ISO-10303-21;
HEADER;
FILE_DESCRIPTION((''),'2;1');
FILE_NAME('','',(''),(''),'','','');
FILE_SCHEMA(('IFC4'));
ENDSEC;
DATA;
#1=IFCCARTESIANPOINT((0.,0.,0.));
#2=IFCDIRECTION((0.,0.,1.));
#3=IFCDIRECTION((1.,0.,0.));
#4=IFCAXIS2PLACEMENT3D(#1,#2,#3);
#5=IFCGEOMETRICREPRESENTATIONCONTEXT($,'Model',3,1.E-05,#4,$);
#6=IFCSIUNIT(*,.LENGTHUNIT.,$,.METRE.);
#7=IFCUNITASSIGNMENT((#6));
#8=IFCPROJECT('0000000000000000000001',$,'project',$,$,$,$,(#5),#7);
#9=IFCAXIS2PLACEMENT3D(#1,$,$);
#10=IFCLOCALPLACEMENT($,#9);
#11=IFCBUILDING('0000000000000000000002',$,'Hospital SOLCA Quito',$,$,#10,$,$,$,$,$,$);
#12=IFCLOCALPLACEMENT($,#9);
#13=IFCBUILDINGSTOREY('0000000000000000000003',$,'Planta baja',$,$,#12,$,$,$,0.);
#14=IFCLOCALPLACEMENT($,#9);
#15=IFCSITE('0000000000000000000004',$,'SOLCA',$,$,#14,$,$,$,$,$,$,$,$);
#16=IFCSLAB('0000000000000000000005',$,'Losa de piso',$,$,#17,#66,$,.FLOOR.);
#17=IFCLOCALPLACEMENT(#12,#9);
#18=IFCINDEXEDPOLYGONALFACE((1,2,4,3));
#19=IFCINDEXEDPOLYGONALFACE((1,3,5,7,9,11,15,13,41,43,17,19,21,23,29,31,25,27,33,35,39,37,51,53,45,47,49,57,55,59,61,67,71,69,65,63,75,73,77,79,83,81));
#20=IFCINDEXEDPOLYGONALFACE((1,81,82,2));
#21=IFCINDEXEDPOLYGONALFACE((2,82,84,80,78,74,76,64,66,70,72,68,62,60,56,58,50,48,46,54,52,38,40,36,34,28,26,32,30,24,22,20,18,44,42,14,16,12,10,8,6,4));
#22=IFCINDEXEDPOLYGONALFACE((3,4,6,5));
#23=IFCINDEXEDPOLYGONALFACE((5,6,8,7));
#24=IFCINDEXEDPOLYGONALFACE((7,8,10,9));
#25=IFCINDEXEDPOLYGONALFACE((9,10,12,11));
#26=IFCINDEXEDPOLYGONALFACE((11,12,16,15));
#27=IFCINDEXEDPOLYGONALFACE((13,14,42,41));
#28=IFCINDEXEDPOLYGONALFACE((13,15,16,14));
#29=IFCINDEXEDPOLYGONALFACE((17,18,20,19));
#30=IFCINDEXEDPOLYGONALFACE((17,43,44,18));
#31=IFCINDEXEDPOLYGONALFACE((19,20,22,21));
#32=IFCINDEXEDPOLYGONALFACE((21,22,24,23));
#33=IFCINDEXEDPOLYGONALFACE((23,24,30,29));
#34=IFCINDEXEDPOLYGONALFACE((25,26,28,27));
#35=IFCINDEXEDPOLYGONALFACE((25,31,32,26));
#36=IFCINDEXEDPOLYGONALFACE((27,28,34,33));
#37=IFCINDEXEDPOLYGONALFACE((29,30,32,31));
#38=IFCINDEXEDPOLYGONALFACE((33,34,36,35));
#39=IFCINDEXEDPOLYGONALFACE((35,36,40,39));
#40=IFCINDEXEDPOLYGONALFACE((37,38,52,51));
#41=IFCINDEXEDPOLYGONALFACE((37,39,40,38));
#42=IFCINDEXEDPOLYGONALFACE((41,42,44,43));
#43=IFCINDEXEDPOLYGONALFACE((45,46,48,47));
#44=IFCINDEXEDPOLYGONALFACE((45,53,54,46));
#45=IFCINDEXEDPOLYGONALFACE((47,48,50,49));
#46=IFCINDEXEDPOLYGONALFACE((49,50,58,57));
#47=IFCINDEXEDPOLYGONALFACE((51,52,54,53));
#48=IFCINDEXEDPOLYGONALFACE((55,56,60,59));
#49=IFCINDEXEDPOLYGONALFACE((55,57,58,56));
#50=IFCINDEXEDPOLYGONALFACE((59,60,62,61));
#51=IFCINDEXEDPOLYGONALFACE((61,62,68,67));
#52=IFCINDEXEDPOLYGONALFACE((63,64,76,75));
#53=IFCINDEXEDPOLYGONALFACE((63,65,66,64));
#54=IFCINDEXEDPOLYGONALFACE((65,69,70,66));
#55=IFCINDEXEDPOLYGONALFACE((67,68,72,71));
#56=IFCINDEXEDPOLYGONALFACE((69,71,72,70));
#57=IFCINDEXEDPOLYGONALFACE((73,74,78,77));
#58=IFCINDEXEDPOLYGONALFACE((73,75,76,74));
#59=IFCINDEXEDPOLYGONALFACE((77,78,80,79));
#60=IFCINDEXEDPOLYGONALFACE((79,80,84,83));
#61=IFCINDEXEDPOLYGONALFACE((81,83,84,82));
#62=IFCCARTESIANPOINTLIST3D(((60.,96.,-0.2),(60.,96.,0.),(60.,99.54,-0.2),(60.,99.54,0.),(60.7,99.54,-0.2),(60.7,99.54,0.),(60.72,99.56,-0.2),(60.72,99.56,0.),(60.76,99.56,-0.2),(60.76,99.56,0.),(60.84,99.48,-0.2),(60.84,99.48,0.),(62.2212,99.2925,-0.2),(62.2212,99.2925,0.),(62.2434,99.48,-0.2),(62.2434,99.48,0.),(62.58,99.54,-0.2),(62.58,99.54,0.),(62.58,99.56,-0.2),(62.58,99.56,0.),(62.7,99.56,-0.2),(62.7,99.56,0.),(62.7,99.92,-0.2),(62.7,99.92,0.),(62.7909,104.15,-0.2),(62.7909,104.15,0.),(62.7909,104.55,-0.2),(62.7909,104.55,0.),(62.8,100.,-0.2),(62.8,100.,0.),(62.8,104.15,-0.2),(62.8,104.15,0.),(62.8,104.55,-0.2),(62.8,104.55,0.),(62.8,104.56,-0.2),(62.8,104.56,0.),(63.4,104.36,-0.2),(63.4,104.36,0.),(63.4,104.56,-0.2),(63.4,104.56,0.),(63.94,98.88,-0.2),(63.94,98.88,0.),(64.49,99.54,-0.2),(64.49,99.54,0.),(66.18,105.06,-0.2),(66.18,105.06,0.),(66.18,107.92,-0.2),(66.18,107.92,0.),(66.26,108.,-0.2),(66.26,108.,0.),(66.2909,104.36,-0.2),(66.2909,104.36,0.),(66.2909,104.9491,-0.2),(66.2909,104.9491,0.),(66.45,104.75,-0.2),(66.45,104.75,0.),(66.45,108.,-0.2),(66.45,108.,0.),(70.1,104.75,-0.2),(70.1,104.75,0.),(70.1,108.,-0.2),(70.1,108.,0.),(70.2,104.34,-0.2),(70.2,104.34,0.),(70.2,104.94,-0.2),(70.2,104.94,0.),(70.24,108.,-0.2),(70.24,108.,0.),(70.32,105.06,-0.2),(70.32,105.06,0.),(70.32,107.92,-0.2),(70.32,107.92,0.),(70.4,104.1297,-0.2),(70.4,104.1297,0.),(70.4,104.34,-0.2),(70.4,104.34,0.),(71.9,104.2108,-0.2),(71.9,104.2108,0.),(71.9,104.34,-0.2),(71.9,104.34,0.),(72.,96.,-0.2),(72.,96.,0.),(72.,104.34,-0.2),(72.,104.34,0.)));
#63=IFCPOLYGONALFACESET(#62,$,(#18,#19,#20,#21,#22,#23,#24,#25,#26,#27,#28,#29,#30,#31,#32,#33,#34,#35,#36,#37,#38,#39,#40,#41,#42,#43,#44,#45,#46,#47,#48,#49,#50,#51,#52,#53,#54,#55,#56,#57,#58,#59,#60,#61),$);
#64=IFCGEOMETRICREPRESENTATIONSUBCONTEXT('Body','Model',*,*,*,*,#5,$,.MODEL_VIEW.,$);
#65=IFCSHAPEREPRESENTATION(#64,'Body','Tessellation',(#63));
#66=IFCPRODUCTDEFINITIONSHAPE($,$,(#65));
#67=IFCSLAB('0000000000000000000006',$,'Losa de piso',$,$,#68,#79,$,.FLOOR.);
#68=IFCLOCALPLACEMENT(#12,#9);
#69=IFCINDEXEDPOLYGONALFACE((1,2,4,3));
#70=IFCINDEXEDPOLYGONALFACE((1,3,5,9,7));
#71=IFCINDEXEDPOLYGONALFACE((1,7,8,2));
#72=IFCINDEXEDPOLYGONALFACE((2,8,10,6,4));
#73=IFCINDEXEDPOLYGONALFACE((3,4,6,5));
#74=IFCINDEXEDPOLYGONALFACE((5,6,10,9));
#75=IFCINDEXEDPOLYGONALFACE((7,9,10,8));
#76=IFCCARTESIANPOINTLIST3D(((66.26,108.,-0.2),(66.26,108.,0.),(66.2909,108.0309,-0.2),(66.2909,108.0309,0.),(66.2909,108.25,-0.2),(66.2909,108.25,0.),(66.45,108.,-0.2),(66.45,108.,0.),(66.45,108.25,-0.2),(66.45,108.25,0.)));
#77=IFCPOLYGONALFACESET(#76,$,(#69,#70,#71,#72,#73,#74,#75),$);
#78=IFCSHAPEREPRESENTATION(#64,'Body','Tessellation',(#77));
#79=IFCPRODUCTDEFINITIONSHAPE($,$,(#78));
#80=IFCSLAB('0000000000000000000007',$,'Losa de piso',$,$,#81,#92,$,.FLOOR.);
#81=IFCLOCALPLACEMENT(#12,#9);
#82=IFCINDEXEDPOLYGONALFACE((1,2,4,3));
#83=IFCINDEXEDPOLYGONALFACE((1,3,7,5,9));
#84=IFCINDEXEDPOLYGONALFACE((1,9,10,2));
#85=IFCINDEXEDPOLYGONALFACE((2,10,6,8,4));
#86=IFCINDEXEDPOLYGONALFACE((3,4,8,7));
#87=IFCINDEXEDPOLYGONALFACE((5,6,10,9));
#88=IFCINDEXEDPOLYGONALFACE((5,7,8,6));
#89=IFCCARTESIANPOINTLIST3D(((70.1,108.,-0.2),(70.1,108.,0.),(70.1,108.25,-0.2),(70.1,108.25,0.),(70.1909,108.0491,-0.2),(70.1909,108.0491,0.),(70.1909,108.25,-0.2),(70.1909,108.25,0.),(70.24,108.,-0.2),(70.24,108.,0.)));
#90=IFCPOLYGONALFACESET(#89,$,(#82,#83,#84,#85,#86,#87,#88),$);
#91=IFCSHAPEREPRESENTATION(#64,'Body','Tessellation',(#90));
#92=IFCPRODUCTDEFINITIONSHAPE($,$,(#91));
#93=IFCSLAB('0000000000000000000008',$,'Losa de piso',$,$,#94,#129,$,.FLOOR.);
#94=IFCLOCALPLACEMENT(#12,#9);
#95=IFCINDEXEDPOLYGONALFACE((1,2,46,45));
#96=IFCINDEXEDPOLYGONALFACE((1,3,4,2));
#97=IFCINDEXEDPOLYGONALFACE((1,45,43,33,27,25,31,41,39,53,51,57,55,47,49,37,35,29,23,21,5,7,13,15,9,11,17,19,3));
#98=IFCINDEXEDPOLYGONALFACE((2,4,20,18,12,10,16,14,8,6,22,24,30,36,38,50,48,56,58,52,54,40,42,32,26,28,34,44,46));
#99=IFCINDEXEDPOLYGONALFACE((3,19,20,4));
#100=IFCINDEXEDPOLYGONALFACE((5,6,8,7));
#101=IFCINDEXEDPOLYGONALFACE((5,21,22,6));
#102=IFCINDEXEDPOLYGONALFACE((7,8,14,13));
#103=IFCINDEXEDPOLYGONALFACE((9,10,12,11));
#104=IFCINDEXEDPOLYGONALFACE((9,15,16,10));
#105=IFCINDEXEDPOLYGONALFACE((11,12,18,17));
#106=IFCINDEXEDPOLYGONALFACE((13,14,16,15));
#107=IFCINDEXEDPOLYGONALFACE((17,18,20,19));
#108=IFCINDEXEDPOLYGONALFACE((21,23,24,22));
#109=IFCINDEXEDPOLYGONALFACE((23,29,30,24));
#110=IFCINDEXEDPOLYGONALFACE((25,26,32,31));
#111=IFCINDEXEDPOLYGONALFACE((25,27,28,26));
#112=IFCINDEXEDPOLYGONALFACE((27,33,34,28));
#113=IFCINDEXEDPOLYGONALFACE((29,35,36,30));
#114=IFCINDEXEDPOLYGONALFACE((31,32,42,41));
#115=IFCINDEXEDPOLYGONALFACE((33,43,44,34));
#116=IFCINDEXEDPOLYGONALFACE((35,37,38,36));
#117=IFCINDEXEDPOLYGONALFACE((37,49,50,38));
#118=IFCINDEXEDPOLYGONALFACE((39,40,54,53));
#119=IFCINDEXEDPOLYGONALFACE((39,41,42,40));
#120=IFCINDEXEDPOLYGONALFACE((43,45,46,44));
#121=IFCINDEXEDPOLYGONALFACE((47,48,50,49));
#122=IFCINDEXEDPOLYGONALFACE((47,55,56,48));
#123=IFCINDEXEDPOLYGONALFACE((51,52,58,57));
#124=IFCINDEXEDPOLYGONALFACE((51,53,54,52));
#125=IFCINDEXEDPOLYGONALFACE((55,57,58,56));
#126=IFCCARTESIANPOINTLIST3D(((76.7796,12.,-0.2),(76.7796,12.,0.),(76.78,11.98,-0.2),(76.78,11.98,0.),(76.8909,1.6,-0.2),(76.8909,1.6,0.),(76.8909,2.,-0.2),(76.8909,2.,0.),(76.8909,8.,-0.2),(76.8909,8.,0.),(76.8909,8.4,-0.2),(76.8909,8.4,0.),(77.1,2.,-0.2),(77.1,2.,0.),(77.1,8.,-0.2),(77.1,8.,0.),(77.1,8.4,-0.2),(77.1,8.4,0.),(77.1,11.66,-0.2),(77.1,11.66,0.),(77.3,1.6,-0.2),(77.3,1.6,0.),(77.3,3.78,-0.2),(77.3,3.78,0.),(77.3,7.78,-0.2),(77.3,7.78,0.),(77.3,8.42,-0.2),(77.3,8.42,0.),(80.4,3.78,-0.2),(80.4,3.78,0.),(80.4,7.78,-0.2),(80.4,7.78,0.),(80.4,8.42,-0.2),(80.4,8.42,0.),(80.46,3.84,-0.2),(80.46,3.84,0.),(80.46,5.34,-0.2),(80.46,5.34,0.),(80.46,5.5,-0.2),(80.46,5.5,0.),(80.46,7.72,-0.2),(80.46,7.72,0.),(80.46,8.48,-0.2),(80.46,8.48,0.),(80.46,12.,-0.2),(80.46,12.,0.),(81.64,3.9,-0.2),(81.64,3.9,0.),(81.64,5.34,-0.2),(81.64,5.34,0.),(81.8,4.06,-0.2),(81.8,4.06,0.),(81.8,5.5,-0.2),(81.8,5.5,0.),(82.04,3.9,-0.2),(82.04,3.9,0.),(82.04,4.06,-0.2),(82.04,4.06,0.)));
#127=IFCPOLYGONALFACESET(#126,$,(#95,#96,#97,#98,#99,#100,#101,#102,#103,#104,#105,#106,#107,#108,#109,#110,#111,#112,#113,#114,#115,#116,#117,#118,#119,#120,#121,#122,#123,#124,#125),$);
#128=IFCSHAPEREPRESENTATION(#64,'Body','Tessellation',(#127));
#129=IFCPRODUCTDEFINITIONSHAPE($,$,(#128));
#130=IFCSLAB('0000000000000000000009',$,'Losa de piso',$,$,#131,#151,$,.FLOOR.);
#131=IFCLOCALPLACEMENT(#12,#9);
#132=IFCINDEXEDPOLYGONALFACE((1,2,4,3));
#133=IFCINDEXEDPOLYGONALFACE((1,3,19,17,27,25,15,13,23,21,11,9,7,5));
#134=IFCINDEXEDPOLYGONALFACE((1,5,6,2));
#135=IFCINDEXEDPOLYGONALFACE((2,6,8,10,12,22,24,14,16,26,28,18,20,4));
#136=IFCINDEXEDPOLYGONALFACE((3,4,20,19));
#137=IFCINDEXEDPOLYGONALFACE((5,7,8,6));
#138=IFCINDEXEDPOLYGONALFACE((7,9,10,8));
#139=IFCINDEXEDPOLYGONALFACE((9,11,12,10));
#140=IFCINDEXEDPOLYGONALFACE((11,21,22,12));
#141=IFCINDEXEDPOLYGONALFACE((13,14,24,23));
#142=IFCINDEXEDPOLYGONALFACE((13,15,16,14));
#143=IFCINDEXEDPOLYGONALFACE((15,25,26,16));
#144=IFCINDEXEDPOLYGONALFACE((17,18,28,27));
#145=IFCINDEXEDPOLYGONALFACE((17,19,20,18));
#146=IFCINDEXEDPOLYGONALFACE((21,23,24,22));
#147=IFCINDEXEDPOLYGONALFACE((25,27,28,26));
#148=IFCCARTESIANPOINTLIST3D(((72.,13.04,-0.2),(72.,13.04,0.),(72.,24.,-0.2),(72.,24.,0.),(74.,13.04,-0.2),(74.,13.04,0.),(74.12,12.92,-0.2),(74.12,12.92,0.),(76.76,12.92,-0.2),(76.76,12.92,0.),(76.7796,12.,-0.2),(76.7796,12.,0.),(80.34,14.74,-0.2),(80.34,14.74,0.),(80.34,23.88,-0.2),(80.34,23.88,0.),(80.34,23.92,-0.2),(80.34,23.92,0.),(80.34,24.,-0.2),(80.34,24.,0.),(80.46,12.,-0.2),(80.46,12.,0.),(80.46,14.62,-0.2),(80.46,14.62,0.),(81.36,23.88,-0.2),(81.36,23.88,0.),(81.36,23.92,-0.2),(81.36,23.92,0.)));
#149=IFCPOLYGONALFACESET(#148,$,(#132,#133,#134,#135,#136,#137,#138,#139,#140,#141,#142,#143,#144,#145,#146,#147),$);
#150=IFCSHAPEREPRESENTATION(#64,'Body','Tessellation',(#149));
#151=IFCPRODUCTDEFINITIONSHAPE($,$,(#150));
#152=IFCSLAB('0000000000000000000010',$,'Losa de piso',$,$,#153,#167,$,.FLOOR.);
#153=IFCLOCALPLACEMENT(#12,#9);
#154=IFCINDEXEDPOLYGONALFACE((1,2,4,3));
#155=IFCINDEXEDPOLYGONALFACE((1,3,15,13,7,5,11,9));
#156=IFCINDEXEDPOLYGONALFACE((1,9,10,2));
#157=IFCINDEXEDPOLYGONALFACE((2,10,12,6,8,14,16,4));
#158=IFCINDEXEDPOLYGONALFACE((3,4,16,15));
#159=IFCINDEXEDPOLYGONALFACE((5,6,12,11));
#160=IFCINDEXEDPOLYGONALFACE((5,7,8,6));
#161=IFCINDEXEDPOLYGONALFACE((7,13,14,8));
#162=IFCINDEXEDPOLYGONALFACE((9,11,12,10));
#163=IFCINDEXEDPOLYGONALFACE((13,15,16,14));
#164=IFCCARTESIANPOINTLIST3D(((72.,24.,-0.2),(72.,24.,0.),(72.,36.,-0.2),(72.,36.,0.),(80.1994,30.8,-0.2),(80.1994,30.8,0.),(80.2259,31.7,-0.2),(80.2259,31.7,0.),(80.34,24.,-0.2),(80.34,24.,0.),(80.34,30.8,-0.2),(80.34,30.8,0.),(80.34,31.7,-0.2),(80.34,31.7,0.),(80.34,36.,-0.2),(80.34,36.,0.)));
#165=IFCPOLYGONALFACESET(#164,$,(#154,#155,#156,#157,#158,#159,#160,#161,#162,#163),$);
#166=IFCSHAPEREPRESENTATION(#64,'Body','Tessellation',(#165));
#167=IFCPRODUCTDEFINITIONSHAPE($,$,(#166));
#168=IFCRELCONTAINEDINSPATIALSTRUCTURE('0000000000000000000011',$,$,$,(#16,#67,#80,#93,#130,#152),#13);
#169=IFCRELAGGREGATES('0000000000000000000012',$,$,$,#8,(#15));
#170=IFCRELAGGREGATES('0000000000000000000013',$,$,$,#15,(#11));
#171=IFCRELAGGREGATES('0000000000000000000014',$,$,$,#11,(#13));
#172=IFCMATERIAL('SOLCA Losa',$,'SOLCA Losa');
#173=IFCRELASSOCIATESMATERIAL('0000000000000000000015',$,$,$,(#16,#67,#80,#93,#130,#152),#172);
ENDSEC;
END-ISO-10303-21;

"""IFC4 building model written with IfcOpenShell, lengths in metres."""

from ifc_helpers import new_model, si_unit, frame, origin, origin_with_axes, place, context, subcontext, project, spatial, polyline, outline, extrude, material, element, save


model = new_model("IFC4")

# Units and contexts
model_context = context("Model", 3, precision=1e-05, world=origin_with_axes())
body_context = subcontext(model_context, "Body", "Model", "MODEL_VIEW")
ifc_project = project(units=[si_unit("LENGTHUNIT", "METRE")], contexts=[model_context])

# Site, building, storey
site_placement = place(None, origin())
site = spatial("IfcSite", under=ifc_project, at=site_placement, Name="SOLCA")
building_placement = place(None, origin())
building = spatial("IfcBuilding", under=site, at=building_placement, Name="Hospital SOLCA Quito")
storey_placement = place(None, origin())
storey = spatial("IfcBuildingStorey", under=building, at=storey_placement, Name="Planta baja", Elevation=0.0)

# Slabs
ifc_material_1 = material(Name="SOLCA Losa", Category="SOLCA Losa")
slab_1_placement = place(storey_placement, origin_with_axes())
element("IfcSlab", 1, at=slab_1_placement, inside=storey, material=ifc_material_1, Name="Losa de piso", PredefinedType="FLOOR", context=body_context, shape_type="SweptSolid", body=[
    extrude(outline(polyline([(60.7, 99.54), (60.72, 99.56), (60.76, 99.56), (60.84, 99.48), (62.2434, 99.48), (62.2212, 99.2925), (63.94, 98.88), (64.49, 99.54), (62.58, 99.54), (62.58, 99.56), (62.7, 99.56), (62.7, 99.92), (62.8, 100.0), (62.8, 104.15), (62.7909, 104.15), (62.7909, 104.55), (62.8, 104.55), (62.8, 104.56), (63.4, 104.56), (63.4, 104.36), (66.2909, 104.36), (66.2909, 104.9491), (66.18, 105.06), (66.18, 107.92), (66.26, 108.0), (66.45, 108.0), (66.45, 104.75), (70.1, 104.75), (70.1, 108.0), (70.24, 108.0), (70.32, 107.92), (70.32, 105.06), (70.2, 104.94), (70.2, 104.34), (70.4, 104.34), (70.4, 104.1297), (71.9, 104.2108), (71.9, 104.34), (72.0, 104.34), (72.0, 96.0), (60.0, 96.0), (60.0, 99.54), (60.7, 99.54)])), frame((0.0, 0.0, -0.2), z_axis=(0.0, 0.0, 1.0), x_axis=(1.0, 0.0, 0.0)), (0.0, 0.0, 1.0), 0.2),
])
slab_2_placement = place(storey_placement, origin_with_axes())
element("IfcSlab", 2, at=slab_2_placement, inside=storey, material=ifc_material_1, Name="Losa de piso", PredefinedType="FLOOR", context=body_context, shape_type="SweptSolid", body=[
    extrude(outline(polyline([(66.2909, 108.0309), (66.2909, 108.25), (66.45, 108.25), (66.45, 108.0), (66.26, 108.0), (66.2909, 108.0309)])), frame((0.0, 0.0, -0.2), z_axis=(0.0, 0.0, 1.0), x_axis=(1.0, 0.0, 0.0)), (0.0, 0.0, 1.0), 0.2),
])
slab_3_placement = place(storey_placement, origin_with_axes())
element("IfcSlab", 3, at=slab_3_placement, inside=storey, material=ifc_material_1, Name="Losa de piso", PredefinedType="FLOOR", context=body_context, shape_type="SweptSolid", body=[
    extrude(outline(polyline([(70.1, 108.25), (70.1909, 108.25), (70.1909, 108.0491), (70.24, 108.0), (70.1, 108.0), (70.1, 108.25)])), frame((0.0, 0.0, -0.2), z_axis=(0.0, 0.0, 1.0), x_axis=(1.0, 0.0, 0.0)), (0.0, 0.0, 1.0), 0.2),
])
slab_4_placement = place(storey_placement, origin_with_axes())
element("IfcSlab", 4, at=slab_4_placement, inside=storey, material=ifc_material_1, Name="Losa de piso", PredefinedType="FLOOR", context=body_context, shape_type="SweptSolid", body=[
    extrude(outline(polyline([(80.46, 8.48), (80.4, 8.42), (77.3, 8.42), (77.3, 7.78), (80.4, 7.78), (80.46, 7.72), (80.46, 5.5), (81.8, 5.5), (81.8, 4.06), (82.04, 4.06), (82.04, 3.9), (81.64, 3.9), (81.64, 5.34), (80.46, 5.34), (80.46, 3.84), (80.4, 3.78), (77.3, 3.78), (77.3, 1.6), (76.8909, 1.6), (76.8909, 2.0), (77.1, 2.0), (77.1, 8.0), (76.8909, 8.0), (76.8909, 8.4), (77.1, 8.4), (77.1, 11.66), (76.78, 11.98), (76.7796, 12.0), (80.46, 12.0), (80.46, 8.48)])), frame((0.0, 0.0, -0.2), z_axis=(0.0, 0.0, 1.0), x_axis=(1.0, 0.0, 0.0)), (0.0, 0.0, 1.0), 0.2),
])
slab_5_placement = place(storey_placement, origin_with_axes())
element("IfcSlab", 5, at=slab_5_placement, inside=storey, material=ifc_material_1, Name="Losa de piso", PredefinedType="FLOOR", context=body_context, shape_type="SweptSolid", body=[
    extrude(outline(polyline([(80.34, 23.92), (81.36, 23.92), (81.36, 23.88), (80.34, 23.88), (80.34, 14.74), (80.46, 14.62), (80.46, 12.0), (76.7796, 12.0), (76.76, 12.92), (74.12, 12.92), (74.0, 13.04), (72.0, 13.04), (72.0, 24.0), (80.34, 24.0), (80.34, 23.92)])), frame((0.0, 0.0, -0.2), z_axis=(0.0, 0.0, 1.0), x_axis=(1.0, 0.0, 0.0)), (0.0, 0.0, 1.0), 0.2),
])
slab_6_placement = place(storey_placement, origin_with_axes())
element("IfcSlab", 6, at=slab_6_placement, inside=storey, material=ifc_material_1, Name="Losa de piso", PredefinedType="FLOOR", context=body_context, shape_type="SweptSolid", body=[
    extrude(outline(polyline([(80.34, 31.7), (80.2259, 31.7), (80.1994, 30.8), (80.34, 30.8), (80.34, 24.0), (72.0, 24.0), (72.0, 36.0), (80.34, 36.0), (80.34, 31.7)])), frame((0.0, 0.0, -0.2), z_axis=(0.0, 0.0, 1.0), x_axis=(1.0, 0.0, 0.0)), (0.0, 0.0, 1.0), 0.2),
])

save(model, "model.ifc")
